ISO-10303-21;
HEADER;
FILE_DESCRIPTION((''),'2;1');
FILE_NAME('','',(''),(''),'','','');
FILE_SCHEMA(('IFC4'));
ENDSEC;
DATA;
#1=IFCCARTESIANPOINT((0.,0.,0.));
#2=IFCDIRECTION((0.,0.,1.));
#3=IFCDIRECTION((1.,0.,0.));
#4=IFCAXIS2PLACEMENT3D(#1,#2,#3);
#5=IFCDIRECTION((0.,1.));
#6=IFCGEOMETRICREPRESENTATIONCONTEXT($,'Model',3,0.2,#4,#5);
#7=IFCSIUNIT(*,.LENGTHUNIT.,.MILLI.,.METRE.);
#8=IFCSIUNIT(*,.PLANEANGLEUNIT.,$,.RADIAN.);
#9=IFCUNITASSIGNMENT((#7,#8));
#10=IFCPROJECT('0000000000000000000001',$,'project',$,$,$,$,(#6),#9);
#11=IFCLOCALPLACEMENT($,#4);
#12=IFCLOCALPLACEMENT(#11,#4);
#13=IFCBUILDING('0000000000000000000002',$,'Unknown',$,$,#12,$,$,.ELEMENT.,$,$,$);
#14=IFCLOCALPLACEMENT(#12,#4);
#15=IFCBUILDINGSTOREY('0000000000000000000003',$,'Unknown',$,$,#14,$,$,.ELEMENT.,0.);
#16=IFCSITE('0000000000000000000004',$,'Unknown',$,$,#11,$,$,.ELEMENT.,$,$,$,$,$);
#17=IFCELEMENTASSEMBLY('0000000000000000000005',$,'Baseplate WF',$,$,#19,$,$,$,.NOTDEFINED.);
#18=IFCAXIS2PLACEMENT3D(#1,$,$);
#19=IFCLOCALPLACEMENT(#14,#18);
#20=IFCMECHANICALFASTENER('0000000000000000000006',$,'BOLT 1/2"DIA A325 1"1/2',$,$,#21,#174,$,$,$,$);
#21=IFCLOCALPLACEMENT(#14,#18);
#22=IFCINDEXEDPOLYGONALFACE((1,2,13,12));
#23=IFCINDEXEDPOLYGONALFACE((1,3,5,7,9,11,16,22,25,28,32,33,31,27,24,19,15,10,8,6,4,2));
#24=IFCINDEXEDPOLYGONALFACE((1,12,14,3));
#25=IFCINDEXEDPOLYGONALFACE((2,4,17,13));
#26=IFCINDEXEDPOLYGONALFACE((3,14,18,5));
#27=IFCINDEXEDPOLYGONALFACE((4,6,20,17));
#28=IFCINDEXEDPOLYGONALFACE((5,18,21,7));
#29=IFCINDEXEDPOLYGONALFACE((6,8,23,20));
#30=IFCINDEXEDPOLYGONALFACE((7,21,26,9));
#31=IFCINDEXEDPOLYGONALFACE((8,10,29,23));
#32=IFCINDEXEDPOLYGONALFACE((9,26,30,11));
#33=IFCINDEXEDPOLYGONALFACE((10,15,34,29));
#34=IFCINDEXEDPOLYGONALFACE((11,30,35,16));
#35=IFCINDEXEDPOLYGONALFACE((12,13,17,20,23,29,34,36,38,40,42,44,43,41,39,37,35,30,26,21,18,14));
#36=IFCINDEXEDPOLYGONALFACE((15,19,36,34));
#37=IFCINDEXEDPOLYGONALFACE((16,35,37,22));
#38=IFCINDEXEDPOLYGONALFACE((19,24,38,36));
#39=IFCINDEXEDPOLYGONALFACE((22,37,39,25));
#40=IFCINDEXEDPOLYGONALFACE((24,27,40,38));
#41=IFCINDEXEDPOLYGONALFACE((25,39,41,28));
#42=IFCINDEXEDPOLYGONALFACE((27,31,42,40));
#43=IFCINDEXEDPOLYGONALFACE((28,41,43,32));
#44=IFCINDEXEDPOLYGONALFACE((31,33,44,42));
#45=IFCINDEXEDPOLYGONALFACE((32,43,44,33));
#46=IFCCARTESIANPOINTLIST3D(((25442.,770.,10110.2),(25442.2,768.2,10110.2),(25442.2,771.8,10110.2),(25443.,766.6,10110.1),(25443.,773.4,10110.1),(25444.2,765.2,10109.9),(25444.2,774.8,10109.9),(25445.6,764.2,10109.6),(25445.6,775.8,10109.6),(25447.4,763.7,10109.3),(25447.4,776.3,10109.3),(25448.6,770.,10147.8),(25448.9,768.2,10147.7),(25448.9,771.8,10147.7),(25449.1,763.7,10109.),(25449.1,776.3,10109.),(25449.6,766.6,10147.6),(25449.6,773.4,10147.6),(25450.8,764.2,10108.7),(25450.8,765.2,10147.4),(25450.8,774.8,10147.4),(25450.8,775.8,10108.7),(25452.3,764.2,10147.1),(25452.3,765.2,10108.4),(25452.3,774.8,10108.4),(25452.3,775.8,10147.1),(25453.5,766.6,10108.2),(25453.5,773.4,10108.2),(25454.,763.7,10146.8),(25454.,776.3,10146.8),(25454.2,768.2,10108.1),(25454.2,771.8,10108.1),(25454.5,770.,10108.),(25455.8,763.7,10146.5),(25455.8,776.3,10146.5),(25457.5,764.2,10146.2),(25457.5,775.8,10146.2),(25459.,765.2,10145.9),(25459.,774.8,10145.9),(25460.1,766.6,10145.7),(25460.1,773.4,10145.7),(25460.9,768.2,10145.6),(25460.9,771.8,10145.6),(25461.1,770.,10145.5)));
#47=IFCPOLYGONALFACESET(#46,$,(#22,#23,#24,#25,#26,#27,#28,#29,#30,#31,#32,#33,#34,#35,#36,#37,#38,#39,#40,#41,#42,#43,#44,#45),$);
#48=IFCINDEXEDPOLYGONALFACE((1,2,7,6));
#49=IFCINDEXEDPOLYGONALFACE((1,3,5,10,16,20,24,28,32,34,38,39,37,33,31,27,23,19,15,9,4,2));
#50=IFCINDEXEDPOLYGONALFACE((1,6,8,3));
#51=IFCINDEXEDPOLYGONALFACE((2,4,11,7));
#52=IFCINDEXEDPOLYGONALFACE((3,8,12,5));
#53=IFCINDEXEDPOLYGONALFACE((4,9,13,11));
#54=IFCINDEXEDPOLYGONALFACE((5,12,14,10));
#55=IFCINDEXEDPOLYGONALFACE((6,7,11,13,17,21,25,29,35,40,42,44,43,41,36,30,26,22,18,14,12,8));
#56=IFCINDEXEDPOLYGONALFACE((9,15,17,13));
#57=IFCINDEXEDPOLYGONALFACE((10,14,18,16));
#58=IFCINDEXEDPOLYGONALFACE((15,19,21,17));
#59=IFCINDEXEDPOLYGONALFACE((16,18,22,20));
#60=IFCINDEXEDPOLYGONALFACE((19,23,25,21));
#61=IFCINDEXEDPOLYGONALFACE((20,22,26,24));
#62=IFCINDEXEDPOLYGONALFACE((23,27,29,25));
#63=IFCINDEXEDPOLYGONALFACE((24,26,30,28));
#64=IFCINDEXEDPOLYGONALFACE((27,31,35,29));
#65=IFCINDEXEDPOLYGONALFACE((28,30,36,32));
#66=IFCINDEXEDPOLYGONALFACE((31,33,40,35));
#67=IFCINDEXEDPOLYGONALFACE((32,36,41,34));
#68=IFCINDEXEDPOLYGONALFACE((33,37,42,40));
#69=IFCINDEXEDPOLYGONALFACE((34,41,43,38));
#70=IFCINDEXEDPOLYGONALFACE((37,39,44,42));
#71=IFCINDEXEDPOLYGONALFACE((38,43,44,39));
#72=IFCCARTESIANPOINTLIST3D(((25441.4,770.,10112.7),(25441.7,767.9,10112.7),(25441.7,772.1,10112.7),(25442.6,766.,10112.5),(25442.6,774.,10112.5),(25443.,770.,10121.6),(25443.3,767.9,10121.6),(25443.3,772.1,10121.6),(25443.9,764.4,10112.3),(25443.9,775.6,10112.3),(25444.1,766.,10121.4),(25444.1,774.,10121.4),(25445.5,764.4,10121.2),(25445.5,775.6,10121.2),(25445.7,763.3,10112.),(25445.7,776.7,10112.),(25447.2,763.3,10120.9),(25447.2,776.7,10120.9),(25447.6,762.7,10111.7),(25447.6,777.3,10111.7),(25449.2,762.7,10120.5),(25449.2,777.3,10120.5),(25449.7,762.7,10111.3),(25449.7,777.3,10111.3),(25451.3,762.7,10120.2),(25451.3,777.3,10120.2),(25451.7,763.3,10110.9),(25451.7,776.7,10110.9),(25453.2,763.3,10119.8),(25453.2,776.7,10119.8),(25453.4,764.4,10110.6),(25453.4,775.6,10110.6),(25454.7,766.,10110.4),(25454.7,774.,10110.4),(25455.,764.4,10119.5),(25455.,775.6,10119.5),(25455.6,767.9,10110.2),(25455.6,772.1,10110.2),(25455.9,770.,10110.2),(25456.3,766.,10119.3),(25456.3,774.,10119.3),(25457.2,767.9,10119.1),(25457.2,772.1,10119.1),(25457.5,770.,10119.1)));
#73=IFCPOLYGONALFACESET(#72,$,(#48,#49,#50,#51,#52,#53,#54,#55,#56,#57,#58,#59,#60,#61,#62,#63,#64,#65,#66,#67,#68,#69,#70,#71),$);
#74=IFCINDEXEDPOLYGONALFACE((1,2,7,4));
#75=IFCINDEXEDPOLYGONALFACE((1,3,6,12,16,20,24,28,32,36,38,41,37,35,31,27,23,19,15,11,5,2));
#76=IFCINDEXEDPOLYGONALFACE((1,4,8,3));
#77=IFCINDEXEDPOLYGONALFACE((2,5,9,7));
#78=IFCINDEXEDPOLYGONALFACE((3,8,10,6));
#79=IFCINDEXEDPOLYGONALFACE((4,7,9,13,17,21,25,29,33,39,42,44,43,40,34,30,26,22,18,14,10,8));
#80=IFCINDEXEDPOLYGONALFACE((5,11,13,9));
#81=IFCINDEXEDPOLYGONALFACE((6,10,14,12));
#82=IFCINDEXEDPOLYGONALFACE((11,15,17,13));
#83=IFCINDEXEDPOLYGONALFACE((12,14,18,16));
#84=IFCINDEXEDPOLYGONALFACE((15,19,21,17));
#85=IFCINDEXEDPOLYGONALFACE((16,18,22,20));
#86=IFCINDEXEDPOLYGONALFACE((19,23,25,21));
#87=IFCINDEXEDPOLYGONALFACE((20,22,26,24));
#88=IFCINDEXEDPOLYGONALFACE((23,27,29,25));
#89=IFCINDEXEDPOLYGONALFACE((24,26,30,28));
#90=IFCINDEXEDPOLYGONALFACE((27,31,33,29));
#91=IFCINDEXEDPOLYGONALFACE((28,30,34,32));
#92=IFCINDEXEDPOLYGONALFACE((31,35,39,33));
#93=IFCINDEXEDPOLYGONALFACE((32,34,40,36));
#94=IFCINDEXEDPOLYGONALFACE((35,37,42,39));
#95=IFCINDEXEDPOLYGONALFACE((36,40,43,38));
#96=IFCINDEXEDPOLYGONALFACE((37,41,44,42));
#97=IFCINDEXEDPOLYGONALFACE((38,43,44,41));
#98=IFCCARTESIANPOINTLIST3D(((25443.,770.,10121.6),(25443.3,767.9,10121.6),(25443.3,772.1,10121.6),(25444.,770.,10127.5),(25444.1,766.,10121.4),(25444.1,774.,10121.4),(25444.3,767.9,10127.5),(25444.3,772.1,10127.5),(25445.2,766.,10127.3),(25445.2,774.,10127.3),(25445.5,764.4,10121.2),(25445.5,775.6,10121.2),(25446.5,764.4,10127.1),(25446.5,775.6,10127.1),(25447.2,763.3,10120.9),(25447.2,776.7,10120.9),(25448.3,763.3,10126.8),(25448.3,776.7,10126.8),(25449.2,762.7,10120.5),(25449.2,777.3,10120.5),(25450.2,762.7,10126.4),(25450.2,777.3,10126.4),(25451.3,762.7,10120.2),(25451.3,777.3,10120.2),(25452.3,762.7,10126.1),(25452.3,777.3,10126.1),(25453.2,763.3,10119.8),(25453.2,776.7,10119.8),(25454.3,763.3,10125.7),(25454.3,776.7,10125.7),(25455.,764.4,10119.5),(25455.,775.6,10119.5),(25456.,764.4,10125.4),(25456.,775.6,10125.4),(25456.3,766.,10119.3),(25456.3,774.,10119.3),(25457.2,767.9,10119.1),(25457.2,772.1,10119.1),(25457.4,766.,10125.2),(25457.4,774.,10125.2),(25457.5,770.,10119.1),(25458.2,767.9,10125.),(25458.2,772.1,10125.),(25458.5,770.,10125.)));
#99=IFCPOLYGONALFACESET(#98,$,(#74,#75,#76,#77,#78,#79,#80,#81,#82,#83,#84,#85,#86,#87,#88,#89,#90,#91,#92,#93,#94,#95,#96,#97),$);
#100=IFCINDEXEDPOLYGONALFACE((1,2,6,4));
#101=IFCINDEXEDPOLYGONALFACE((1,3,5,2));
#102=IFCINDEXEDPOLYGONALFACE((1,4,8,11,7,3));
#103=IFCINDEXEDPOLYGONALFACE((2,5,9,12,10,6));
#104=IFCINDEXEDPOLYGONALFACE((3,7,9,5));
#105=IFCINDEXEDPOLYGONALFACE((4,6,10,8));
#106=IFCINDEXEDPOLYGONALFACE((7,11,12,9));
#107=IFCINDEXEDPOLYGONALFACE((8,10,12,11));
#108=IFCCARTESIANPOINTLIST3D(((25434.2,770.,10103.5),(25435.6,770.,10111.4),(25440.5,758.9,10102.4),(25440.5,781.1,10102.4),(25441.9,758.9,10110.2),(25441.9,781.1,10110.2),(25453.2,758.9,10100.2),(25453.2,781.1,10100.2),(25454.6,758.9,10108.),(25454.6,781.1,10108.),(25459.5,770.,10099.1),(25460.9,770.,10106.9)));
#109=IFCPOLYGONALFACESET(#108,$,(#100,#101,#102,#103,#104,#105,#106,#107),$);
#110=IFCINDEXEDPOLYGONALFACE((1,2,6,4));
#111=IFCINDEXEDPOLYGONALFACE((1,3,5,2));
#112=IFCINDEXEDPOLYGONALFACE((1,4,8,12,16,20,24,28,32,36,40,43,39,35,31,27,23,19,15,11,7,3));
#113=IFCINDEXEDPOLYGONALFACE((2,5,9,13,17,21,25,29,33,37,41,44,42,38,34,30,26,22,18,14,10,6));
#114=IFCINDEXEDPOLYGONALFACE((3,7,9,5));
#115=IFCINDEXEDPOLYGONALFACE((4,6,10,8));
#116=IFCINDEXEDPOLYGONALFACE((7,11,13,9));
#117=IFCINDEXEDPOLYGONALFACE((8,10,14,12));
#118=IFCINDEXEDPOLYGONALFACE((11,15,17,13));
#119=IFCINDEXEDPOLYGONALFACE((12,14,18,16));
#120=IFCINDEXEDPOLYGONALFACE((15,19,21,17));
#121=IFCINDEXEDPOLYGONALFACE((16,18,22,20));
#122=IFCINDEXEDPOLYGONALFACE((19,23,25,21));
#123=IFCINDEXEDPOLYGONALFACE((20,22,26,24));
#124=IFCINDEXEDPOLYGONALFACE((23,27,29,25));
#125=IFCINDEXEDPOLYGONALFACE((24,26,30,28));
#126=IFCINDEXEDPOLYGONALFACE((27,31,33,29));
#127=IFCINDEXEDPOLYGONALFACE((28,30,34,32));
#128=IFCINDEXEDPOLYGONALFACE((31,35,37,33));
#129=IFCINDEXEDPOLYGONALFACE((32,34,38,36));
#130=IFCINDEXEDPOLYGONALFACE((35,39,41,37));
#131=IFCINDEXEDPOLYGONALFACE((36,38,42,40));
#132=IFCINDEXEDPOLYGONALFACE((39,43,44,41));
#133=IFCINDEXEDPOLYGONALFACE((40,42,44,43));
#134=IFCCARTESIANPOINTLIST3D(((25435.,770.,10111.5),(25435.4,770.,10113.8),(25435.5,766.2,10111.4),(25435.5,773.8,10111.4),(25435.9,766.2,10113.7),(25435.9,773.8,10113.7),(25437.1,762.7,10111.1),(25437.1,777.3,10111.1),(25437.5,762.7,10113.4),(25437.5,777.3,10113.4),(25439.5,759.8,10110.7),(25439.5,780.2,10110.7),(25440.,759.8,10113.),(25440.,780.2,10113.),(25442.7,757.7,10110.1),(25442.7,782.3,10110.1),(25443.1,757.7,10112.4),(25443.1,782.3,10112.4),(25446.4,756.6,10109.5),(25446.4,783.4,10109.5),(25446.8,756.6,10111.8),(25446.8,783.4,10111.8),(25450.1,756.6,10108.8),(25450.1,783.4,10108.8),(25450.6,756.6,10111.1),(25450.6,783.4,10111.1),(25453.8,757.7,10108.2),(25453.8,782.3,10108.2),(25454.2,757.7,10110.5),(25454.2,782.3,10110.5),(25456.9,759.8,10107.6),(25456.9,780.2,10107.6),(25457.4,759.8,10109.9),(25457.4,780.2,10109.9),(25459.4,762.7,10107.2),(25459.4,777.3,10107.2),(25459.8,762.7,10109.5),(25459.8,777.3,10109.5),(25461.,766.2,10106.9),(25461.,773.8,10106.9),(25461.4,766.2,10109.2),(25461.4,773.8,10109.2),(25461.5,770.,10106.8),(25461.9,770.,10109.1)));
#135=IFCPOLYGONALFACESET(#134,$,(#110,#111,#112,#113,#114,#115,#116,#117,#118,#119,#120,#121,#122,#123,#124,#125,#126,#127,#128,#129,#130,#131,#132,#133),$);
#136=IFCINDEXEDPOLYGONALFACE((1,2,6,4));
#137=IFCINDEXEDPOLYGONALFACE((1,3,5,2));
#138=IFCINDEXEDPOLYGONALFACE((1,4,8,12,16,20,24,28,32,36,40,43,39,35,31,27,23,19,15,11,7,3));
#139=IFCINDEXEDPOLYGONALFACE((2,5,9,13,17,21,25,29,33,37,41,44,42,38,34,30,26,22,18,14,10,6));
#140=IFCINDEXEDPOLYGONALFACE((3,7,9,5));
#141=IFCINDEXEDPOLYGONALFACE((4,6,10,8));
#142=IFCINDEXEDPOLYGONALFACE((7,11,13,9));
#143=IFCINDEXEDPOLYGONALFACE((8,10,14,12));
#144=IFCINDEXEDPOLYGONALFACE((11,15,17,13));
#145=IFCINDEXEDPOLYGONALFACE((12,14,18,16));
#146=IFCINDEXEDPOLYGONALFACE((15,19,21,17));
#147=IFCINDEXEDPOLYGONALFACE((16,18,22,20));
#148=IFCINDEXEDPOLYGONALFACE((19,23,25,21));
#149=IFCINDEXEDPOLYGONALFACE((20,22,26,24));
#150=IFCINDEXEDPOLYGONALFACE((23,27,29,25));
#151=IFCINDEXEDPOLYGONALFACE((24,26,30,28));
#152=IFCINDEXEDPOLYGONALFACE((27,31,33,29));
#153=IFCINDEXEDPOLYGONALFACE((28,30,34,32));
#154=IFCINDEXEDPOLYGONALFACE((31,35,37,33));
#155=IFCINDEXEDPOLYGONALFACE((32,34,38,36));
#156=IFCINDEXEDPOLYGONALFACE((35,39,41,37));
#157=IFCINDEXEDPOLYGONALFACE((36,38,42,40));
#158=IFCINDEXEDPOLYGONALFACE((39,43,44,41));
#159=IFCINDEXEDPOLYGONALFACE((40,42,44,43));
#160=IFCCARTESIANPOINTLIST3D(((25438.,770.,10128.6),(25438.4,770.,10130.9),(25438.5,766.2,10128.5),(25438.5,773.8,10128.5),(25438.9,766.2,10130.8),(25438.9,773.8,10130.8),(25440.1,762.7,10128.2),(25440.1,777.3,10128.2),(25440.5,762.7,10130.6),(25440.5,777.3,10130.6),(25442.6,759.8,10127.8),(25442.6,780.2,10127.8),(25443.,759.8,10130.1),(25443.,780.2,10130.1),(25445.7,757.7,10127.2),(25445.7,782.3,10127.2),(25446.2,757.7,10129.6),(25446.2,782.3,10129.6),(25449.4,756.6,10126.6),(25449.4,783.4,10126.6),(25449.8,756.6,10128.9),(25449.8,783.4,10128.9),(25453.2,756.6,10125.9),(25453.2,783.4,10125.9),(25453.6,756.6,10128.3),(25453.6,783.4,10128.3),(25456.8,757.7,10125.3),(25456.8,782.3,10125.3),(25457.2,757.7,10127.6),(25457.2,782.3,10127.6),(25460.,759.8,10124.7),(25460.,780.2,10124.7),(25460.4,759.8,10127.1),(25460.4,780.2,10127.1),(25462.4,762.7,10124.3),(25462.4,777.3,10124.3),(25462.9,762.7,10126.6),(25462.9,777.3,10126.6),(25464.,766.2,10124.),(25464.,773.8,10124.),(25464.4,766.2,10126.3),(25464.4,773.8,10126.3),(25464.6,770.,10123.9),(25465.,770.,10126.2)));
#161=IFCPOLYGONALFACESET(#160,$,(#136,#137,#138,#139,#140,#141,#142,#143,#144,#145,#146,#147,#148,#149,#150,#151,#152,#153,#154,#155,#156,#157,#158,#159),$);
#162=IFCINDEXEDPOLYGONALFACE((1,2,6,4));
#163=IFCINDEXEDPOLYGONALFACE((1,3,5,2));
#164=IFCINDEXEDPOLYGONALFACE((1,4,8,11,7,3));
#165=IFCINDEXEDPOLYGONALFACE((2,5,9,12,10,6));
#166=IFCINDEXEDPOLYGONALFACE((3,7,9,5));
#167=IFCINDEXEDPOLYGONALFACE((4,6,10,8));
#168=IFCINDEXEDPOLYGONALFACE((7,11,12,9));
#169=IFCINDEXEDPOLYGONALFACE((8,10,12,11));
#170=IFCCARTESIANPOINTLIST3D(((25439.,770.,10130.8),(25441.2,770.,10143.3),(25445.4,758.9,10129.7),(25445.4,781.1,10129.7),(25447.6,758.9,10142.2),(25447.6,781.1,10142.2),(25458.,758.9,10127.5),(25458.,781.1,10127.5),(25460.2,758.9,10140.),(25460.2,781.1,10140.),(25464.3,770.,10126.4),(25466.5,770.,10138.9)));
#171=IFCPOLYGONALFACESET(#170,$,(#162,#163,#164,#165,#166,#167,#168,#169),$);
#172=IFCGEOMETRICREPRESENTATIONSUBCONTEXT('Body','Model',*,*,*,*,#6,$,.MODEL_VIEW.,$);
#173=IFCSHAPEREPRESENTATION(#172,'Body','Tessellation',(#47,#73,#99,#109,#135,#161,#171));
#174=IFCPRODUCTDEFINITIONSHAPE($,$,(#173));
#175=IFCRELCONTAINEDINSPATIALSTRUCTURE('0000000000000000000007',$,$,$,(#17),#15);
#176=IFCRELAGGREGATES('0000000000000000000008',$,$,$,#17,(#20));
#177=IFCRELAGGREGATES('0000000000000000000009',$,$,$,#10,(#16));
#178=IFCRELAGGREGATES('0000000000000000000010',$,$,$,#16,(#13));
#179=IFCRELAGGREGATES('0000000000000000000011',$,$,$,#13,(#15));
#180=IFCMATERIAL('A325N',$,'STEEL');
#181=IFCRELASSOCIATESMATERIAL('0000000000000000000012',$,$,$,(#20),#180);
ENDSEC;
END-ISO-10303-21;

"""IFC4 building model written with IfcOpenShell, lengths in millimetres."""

from ifc_helpers import new_model, si_unit, direction, frame, origin_with_axes, place, context, subcontext, project, spatial, line, arc, indexed_curve, outline, extrude, source, transform, mapped, material, element, aggregate, save


model = new_model("IFC4")

# Units and contexts
model_context = context("Model", 3, precision=0.2, world=origin_with_axes(), true_north=direction((0.0, 1.0)))
body_context = subcontext(model_context, "Body", "Model", "MODEL_VIEW")
ifc_project = project(units=[si_unit("LENGTHUNIT", "METRE", prefix="MILLI"), si_unit("PLANEANGLEUNIT", "RADIAN")], contexts=[model_context])

# Site, building, storey
site_placement = place(None, origin_with_axes())
site = spatial("IfcSite", under=ifc_project, at=site_placement, Name="Unknown", CompositionType="ELEMENT")
building_placement = place(site_placement, origin_with_axes())
building = spatial("IfcBuilding", under=site, at=building_placement, Name="Unknown", CompositionType="ELEMENT")
storey_placement = place(building_placement, origin_with_axes())
storey = spatial("IfcBuildingStorey", under=building, at=storey_placement, Name="Unknown", CompositionType="ELEMENT", Elevation=0.0)

# Element assembly
assembly_1_placement = place(storey_placement, frame((25480.3, 800.0, 10118.1), z_axis=(-0.173648, 0.0, -0.984808), x_axis=(0.0, -1.0, 0.0)))
assembly_1 = element("IfcElementAssembly", 1, at=assembly_1_placement, inside=storey, Name="Baseplate WF", PredefinedType="NOTDEFINED")

# Mechanical fastener
ifc_material_1 = material(Name="A325N", Category="STEEL")
shared_shape_1 = source(origin_with_axes(), body_context, "Body", "SweptSolid", [
    extrude(outline(indexed_curve([(6.3, 0.0), (0.0, 6.3), (-6.3, 0.0), (0.0, -6.3)], segments=[arc(1, 2, 3), arc(3, 4, 1)])), frame((0.0, 0.0, 17.4), z_axis=(0.0, 0.0, -1.0), x_axis=(0.0, 1.0, 0.0)), (0.0, 0.0, 1.0), 38.1),
    extrude(outline(indexed_curve([(7.3, 0.0), (0.0, 7.3), (-7.3, 0.0), (0.0, -7.3)], segments=[arc(1, 2, 3), arc(3, 4, 1)])), frame((0.0, 0.0, 15.0), z_axis=(0.0, 0.0, -1.0), x_axis=(0.0, 1.0, 0.0)), (0.0, 0.0, 1.0), 9.0),
    extrude(outline(indexed_curve([(7.3, 0.0), (0.0, 7.3), (-7.3, 0.0), (0.0, -7.3)], segments=[arc(1, 2, 3), arc(3, 4, 1)])), frame((0.0, 0.0, 6.0), z_axis=(0.0, 0.0, -1.0), x_axis=(0.0, 1.0, 0.0)), (0.0, 0.0, 1.0), 6.0),
    extrude(outline(indexed_curve([(12.8, 0.0), (6.4, 11.1), (-6.4, 11.1), (-12.8, 0.0), (-6.4, -11.1), (6.4, -11.1)], segments=[line(1, 2, 3, 4, 5, 6, 1)])), frame((0.0, 0.0, 25.3), z_axis=(0.0, 0.0, -1.0), x_axis=(0.0, 1.0, 0.0)), (0.0, 0.0, 1.0), 7.9),
    extrude(outline(indexed_curve([(13.5, 0.0), (0.0, 13.5), (-13.5, 0.0), (0.0, -13.5)], segments=[arc(1, 2, 3), arc(3, 4, 1)])), frame((0.0, 0.0, 17.4), z_axis=(0.0, 0.0, -1.0), x_axis=(0.0, 1.0, 0.0)), (0.0, 0.0, 1.0), 2.4),
    extrude(outline(indexed_curve([(13.5, 0.0), (0.0, 13.5), (-13.5, 0.0), (0.0, -13.5)], segments=[arc(1, 2, 3), arc(3, 4, 1)])), frame((0.0, 0.0, 0.0), z_axis=(0.0, 0.0, -1.0), x_axis=(0.0, 1.0, 0.0)), (0.0, 0.0, 1.0), 2.4),
    extrude(outline(indexed_curve([(12.8, 0.0), (6.4, 11.1), (-6.4, 11.1), (-12.8, 0.0), (-6.4, -11.1), (6.4, -11.1)], segments=[line(1, 2, 3, 4, 5, 6, 1)])), frame((0.0, 0.0, -2.4), z_axis=(0.0, 0.0, -1.0), x_axis=(0.0, 1.0, 0.0)), (0.0, 0.0, 1.0), 12.7),
])
mechanical_fastener_1_placement = place(assembly_1_placement, frame((30.0, 30.0, -3.0), z_axis=(0.0, 0.0, 1.0), x_axis=(1.0, 0.0, 0.0)))
mechanical_fastener_1 = element("IfcMechanicalFastener", 2, at=mechanical_fastener_1_placement, material=ifc_material_1, Name="BOLT 1/2\"DIA A325 1\"1/2", context=body_context, shape_type="MappedRepresentation", body=[
    mapped(shared_shape_1, transform((0.0, 0.0, 0.0))),
])
aggregate(assembly_1, [mechanical_fastener_1])

save(model, "model.ifc")
